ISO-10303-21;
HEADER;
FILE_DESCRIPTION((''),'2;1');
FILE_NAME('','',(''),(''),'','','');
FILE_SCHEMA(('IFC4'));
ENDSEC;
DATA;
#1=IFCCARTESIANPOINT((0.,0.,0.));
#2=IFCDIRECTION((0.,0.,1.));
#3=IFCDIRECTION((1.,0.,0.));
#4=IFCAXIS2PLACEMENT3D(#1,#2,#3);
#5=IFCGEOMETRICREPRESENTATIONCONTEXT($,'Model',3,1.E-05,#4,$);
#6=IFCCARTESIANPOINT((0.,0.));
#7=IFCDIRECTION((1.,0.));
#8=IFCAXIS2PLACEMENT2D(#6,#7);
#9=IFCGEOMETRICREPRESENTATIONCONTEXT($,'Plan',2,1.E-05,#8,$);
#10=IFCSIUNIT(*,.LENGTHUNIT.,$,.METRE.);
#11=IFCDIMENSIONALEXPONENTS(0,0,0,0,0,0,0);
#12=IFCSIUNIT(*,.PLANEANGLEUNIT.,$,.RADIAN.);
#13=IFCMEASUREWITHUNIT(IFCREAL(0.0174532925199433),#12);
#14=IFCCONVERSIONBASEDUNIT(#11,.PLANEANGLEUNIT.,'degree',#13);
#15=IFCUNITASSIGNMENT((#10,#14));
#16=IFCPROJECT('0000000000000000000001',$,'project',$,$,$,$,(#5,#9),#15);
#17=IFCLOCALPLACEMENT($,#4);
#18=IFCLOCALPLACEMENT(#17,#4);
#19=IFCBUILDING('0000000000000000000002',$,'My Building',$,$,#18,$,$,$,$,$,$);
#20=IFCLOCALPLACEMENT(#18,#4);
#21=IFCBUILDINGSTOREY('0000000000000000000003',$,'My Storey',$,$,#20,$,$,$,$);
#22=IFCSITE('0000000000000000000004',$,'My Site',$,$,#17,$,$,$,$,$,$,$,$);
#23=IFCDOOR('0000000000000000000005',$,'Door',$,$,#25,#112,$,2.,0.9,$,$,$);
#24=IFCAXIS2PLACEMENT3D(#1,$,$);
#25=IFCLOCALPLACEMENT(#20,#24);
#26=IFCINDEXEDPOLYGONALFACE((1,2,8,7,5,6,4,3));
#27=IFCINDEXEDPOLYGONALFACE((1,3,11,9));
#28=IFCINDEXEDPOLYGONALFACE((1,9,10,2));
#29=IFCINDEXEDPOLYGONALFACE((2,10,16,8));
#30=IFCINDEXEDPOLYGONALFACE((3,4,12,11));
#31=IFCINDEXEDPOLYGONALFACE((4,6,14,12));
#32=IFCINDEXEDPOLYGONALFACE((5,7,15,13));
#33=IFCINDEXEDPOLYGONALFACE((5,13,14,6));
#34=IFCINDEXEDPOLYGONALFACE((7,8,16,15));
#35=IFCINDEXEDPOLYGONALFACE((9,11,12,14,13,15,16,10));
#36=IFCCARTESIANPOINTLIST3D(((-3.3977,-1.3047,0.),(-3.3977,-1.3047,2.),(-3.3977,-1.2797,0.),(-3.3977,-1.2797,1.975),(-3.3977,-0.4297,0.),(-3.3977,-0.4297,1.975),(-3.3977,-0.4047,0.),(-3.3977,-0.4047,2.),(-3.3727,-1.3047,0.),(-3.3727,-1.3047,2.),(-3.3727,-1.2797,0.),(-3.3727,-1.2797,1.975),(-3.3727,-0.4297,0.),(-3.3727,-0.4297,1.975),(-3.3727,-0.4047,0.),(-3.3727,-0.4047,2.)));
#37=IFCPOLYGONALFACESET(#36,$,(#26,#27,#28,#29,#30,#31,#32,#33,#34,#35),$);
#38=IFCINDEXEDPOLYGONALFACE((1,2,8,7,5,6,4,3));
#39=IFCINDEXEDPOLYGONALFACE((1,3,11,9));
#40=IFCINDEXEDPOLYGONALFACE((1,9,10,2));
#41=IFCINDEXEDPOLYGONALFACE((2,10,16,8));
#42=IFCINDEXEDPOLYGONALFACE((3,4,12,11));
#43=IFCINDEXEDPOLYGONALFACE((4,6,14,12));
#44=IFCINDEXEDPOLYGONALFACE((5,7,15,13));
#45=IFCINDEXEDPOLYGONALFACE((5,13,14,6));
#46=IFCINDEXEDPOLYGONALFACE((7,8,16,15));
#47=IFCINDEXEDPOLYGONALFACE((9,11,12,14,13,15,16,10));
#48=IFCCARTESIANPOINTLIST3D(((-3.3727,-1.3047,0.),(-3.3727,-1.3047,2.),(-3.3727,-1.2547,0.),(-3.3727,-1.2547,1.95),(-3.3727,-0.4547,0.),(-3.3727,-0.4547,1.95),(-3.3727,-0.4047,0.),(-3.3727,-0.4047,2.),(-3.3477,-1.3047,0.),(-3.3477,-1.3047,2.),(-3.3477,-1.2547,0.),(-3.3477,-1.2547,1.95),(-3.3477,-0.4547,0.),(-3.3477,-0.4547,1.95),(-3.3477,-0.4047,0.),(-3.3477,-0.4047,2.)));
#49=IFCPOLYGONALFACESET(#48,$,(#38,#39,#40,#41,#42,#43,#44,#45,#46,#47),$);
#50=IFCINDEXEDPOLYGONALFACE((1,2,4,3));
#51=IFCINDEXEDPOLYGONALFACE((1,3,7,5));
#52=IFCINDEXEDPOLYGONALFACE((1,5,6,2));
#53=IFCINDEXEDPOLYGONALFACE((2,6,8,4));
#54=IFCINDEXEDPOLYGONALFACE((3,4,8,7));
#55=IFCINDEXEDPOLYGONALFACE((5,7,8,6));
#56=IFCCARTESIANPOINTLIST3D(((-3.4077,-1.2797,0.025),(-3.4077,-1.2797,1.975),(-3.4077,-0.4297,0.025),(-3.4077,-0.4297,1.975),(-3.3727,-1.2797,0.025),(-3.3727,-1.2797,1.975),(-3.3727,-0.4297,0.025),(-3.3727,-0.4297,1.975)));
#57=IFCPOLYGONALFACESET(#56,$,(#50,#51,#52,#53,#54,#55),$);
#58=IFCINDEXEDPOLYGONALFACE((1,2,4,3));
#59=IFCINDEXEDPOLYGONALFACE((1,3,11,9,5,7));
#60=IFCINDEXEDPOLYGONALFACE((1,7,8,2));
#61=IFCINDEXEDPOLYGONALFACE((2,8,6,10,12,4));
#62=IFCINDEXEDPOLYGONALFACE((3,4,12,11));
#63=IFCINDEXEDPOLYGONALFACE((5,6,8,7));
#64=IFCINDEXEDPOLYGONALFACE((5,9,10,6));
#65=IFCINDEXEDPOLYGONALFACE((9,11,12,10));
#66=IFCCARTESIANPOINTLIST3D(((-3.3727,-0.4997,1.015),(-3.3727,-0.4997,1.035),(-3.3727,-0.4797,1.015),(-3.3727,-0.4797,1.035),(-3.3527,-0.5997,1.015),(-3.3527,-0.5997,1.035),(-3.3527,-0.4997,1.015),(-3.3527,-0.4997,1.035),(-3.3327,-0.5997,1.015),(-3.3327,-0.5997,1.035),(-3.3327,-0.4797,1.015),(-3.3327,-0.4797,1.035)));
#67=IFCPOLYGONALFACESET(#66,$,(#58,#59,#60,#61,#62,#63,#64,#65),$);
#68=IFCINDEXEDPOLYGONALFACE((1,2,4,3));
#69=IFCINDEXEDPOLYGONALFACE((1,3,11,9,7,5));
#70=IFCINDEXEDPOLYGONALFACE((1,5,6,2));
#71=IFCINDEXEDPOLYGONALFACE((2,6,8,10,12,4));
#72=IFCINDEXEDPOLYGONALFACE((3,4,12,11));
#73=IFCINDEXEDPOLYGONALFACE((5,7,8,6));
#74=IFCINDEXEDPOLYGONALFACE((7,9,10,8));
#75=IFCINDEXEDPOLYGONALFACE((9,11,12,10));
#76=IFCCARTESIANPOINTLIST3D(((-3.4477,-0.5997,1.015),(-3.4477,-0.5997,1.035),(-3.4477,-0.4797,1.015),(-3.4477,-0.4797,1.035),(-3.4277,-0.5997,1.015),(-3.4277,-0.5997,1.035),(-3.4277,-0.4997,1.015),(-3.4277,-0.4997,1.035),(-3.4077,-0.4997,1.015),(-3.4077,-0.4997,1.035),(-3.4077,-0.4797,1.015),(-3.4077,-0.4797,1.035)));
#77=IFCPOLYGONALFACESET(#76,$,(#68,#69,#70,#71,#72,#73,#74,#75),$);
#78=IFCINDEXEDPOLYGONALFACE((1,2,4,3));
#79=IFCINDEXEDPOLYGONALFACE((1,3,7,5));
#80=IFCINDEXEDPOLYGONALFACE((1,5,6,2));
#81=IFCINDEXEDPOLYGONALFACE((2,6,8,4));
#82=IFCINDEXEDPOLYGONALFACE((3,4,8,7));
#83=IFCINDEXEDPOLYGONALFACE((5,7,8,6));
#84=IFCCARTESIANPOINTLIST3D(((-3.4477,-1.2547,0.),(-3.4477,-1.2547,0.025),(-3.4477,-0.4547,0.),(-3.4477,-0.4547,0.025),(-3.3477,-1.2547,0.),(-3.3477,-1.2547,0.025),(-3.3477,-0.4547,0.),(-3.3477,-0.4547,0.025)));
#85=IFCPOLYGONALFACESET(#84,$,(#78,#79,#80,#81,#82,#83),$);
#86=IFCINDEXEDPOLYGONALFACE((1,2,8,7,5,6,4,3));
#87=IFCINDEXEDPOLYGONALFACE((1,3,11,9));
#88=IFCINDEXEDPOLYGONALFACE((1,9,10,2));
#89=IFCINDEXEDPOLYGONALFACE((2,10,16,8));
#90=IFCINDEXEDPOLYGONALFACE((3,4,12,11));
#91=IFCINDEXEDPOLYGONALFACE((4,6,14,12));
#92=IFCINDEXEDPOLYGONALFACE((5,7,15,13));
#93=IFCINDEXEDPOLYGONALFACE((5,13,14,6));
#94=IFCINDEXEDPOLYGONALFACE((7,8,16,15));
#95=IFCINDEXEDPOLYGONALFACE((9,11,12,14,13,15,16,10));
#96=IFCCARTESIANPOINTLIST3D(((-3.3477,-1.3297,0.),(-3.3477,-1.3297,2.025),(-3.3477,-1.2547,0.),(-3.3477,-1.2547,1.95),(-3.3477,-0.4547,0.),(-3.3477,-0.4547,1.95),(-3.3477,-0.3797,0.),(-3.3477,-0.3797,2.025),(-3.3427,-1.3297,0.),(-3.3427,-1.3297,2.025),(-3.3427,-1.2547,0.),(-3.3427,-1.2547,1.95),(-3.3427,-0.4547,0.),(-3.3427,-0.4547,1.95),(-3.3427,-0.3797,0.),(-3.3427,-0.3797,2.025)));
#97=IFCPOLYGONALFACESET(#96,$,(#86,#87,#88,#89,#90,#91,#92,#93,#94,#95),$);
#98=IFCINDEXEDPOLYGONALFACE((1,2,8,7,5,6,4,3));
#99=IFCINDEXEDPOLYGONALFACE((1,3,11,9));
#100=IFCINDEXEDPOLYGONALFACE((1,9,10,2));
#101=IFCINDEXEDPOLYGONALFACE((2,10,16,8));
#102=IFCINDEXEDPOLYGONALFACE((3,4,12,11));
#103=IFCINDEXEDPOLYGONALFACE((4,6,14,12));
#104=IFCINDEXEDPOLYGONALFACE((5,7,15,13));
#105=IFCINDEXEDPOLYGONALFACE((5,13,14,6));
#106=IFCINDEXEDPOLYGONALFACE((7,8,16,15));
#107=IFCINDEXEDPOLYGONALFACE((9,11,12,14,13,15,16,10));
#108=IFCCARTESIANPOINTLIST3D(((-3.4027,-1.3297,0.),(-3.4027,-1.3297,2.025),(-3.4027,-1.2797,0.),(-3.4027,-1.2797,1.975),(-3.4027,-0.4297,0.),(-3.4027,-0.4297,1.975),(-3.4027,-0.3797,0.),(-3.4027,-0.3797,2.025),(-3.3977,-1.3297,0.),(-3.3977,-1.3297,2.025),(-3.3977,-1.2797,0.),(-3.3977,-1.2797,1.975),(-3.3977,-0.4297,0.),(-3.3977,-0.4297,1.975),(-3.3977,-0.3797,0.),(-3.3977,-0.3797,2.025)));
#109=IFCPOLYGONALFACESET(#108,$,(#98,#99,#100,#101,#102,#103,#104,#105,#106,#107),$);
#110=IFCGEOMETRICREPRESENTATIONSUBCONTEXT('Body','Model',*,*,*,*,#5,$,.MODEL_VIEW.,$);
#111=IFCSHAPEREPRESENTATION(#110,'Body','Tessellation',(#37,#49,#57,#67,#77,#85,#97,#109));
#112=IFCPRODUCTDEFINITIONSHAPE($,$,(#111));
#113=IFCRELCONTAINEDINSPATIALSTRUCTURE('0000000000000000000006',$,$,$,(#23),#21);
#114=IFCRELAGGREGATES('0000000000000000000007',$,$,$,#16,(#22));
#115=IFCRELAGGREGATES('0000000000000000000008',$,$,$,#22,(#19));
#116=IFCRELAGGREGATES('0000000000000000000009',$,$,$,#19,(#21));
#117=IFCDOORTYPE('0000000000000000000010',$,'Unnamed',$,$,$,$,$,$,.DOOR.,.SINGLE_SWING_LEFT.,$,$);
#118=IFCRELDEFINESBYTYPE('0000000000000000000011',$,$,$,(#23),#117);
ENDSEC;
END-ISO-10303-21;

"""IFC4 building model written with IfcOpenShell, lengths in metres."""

from ifc_helpers import new_model, entity, si_unit, converted_unit, frame, origin_with_axes, origin_2d_with_axis, place, context, subcontext, project, spatial, line, indexed_curve, outline, extrude, shape, source, transform, mapped, type_object, type_shapes, element, save


model = new_model("IFC4")

# Units and contexts
model_context = context("Model", 3, precision=1e-05, world=origin_with_axes())
plan_context = context("Plan", 2, precision=1e-05, world=origin_2d_with_axis())
body_context_1 = subcontext(model_context, "Body", "Model", "MODEL_VIEW")
body_context_2 = subcontext(plan_context, "Body", "Plan", "PLAN_VIEW")
ifc_project = project(units=[si_unit("LENGTHUNIT", "METRE"), converted_unit("PLANEANGLEUNIT", "degree", entity("IfcReal", 0.0174532925199433), si_unit("PLANEANGLEUNIT", "RADIAN"), dimensions=[0, 0, 0, 0, 0, 0, 0])], contexts=[model_context, plan_context])

# Site, building, storey
site_placement = place(None, origin_with_axes())
site = spatial("IfcSite", under=ifc_project, at=site_placement, Name="My Site")
building_placement = place(site_placement, origin_with_axes())
building = spatial("IfcBuilding", under=site, at=building_placement, Name="My Building")
storey_placement = place(building_placement, origin_with_axes())
storey = spatial("IfcBuildingStorey", under=building, at=storey_placement, Name="My Storey")

# Shared definitions
door_type = type_object("IfcDoorType", Name="Unnamed", OperationType="SINGLE_SWING_LEFT", PredefinedType="DOOR")
shared_shape_1 = source(origin_with_axes(), body_context_1, "Body", "SweptSolid", [
    extrude(outline(indexed_curve([(0.0, 0.0), (0.0, 2.0), (0.9, 2.0), (0.9, 0.0), (0.875, 0.0), (0.875, 1.975), (0.025, 1.975), (0.025, 0.0)], segments=[line(1, 2, 3, 4, 5, 6, 7, 8, 1)])), frame((0.0, 0.025, 0.0), z_axis=(0.0, -1.0, 0.0), x_axis=(1.0, 0.0, 0.0)), (0.0, 0.0, -1.0), 0.025),
    extrude(outline(indexed_curve([(0.0, 0.0), (0.0, 2.0), (0.9, 2.0), (0.9, 0.0), (0.85, 0.0), (0.85, 1.95), (0.05, 1.95), (0.05, 0.0)], segments=[line(1, 2, 3, 4, 5, 6, 7, 8, 1)])), frame((0.0, 0.0, 0.0), z_axis=(0.0, -1.0, 0.0), x_axis=(1.0, 0.0, 0.0)), (0.0, 0.0, -1.0), 0.025),
    extrude(outline(indexed_curve([(0.0, 0.0), (0.85, 0.0), (0.85, 0.035), (0.0, 0.035)], segments=[line(1, 2, 3, 4, 1)])), frame((0.025, 0.025, 0.025), z_axis=(0.0, 0.0, 1.0), x_axis=(1.0, 0.0, 0.0)), (0.0, 0.0, 1.0), 1.95),
    extrude(outline(indexed_curve([(0.0, 0.0), (0.0, -0.04), (-0.12, -0.04), (-0.12, -0.02), (-0.02, -0.02), (-0.02, 0.0)], segments=[line(1, 2, 3, 4, 5, 6, 1)])), frame((0.825, 0.025, 1.015), z_axis=(0.0, 0.0, 1.0), x_axis=(1.0, 0.0, 0.0)), (0.0, 0.0, 1.0), 0.02),
    extrude(outline(indexed_curve([(0.0, 0.0), (0.0, 0.04), (-0.12, 0.04), (-0.12, 0.02), (-0.02, 0.02), (-0.02, 0.0)], segments=[line(1, 2, 3, 4, 5, 6, 1)])), frame((0.825, 0.06, 1.015), z_axis=(0.0, 0.0, 1.0), x_axis=(1.0, 0.0, 0.0)), (0.0, 0.0, 1.0), 0.02),
    extrude(outline(indexed_curve([(0.0, 0.0), (0.8, 0.0), (0.8, 0.1), (0.0, 0.1)], segments=[line(1, 2, 3, 4, 1)])), frame((0.05, 0.0, 0.0), z_axis=(0.0, 0.0, 1.0), x_axis=(1.0, 0.0, 0.0)), (0.0, 0.0, 1.0), 0.025),
    extrude(outline(indexed_curve([(0.0, 0.0), (0.0, 2.025), (0.95, 2.025), (0.95, 0.0), (0.875, 0.0), (0.875, 1.95), (0.075, 1.95), (0.075, 0.0)], segments=[line(1, 2, 3, 4, 5, 6, 7, 8, 1)])), frame((-0.025, -0.005, 0.0), z_axis=(0.0, -1.0, 0.0), x_axis=(1.0, 0.0, 0.0)), (0.0, 0.0, -1.0), 0.005),
    extrude(outline(indexed_curve([(0.0, 0.0), (0.0, 2.025), (0.95, 2.025), (0.95, 0.0), (0.9, 0.0), (0.9, 1.975), (0.05, 1.975), (0.05, 0.0)], segments=[line(1, 2, 3, 4, 5, 6, 7, 8, 1)])), frame((-0.025, 0.05, 0.0), z_axis=(0.0, -1.0, 0.0), x_axis=(1.0, 0.0, 0.0)), (0.0, 0.0, -1.0), 0.005),
])
shared_shape_2 = source(origin_with_axes(), body_context_2, "Body", "Curve2D", [
    entity("IfcIndexedPolyCurve", entity("IfcCartesianPointList2D", [[0.0, 0.0], [0.0, 0.05], [0.025, 0.05], [0.025, 0.025], [0.05, 0.025], [0.05, 0.0]]), [entity("IfcLineIndex", [1, 2, 3, 4, 5, 6, 1])]),
    entity("IfcIndexedPolyCurve", entity("IfcCartesianPointList2D", [[0.9, 0.0], [0.9, 0.05], [0.875, 0.05], [0.875, 0.025], [0.85, 0.025], [0.85, 0.0]]), [entity("IfcLineIndex", [1, 2, 3, 4, 5, 6, 1])]),
    entity("IfcTrimmedCurve", entity("IfcEllipse", entity("IfcAxis2Placement2D", entity("IfcCartesianPoint", [0.06, 0.05]), entity("IfcDirection", [1.0, 0.0])), 0.815, 0.85), [entity("IfcCartesianPoint", [0.875, 0.05])], [entity("IfcCartesianPoint", [0.06, 0.9])], True, "CARTESIAN"),
    entity("IfcIndexedPolyCurve", entity("IfcCartesianPointList2D", [[0.025, 0.05], [0.06, 0.05], [0.06, 0.9], [0.025, 0.9]]), [entity("IfcLineIndex", [1, 2, 3, 4, 1])]),
])
type_shapes(door_type, [shared_shape_1, shared_shape_2])

# Door
door_1_placement = place(storey_placement, frame((-3.3477, -1.3047, 0.0), z_axis=(0.0, 0.0, 1.0), x_axis=(0.0, 1.0, 0.0)))
element("IfcDoor", 1, at=door_1_placement, inside=storey, type_object=door_type, Name="Door", OverallHeight=2.0, OverallWidth=0.9, shapes=[
    shape(body_context_1, "Body", "MappedRepresentation", [mapped(shared_shape_1, transform((0.0, 0.0, 0.0), x_axis=(1.0, 0.0, 0.0), y_axis=(0.0, 1.0, 0.0), z_axis=(0.0, 0.0, 1.0), scale=1.0))]),
    shape(body_context_2, "Body", "MappedRepresentation", [mapped(shared_shape_2, transform((0.0, 0.0, 0.0), x_axis=(1.0, 0.0, 0.0), y_axis=(0.0, 1.0, 0.0), z_axis=(0.0, 0.0, 1.0), scale=1.0))]),
])

save(model, "model.ifc")
